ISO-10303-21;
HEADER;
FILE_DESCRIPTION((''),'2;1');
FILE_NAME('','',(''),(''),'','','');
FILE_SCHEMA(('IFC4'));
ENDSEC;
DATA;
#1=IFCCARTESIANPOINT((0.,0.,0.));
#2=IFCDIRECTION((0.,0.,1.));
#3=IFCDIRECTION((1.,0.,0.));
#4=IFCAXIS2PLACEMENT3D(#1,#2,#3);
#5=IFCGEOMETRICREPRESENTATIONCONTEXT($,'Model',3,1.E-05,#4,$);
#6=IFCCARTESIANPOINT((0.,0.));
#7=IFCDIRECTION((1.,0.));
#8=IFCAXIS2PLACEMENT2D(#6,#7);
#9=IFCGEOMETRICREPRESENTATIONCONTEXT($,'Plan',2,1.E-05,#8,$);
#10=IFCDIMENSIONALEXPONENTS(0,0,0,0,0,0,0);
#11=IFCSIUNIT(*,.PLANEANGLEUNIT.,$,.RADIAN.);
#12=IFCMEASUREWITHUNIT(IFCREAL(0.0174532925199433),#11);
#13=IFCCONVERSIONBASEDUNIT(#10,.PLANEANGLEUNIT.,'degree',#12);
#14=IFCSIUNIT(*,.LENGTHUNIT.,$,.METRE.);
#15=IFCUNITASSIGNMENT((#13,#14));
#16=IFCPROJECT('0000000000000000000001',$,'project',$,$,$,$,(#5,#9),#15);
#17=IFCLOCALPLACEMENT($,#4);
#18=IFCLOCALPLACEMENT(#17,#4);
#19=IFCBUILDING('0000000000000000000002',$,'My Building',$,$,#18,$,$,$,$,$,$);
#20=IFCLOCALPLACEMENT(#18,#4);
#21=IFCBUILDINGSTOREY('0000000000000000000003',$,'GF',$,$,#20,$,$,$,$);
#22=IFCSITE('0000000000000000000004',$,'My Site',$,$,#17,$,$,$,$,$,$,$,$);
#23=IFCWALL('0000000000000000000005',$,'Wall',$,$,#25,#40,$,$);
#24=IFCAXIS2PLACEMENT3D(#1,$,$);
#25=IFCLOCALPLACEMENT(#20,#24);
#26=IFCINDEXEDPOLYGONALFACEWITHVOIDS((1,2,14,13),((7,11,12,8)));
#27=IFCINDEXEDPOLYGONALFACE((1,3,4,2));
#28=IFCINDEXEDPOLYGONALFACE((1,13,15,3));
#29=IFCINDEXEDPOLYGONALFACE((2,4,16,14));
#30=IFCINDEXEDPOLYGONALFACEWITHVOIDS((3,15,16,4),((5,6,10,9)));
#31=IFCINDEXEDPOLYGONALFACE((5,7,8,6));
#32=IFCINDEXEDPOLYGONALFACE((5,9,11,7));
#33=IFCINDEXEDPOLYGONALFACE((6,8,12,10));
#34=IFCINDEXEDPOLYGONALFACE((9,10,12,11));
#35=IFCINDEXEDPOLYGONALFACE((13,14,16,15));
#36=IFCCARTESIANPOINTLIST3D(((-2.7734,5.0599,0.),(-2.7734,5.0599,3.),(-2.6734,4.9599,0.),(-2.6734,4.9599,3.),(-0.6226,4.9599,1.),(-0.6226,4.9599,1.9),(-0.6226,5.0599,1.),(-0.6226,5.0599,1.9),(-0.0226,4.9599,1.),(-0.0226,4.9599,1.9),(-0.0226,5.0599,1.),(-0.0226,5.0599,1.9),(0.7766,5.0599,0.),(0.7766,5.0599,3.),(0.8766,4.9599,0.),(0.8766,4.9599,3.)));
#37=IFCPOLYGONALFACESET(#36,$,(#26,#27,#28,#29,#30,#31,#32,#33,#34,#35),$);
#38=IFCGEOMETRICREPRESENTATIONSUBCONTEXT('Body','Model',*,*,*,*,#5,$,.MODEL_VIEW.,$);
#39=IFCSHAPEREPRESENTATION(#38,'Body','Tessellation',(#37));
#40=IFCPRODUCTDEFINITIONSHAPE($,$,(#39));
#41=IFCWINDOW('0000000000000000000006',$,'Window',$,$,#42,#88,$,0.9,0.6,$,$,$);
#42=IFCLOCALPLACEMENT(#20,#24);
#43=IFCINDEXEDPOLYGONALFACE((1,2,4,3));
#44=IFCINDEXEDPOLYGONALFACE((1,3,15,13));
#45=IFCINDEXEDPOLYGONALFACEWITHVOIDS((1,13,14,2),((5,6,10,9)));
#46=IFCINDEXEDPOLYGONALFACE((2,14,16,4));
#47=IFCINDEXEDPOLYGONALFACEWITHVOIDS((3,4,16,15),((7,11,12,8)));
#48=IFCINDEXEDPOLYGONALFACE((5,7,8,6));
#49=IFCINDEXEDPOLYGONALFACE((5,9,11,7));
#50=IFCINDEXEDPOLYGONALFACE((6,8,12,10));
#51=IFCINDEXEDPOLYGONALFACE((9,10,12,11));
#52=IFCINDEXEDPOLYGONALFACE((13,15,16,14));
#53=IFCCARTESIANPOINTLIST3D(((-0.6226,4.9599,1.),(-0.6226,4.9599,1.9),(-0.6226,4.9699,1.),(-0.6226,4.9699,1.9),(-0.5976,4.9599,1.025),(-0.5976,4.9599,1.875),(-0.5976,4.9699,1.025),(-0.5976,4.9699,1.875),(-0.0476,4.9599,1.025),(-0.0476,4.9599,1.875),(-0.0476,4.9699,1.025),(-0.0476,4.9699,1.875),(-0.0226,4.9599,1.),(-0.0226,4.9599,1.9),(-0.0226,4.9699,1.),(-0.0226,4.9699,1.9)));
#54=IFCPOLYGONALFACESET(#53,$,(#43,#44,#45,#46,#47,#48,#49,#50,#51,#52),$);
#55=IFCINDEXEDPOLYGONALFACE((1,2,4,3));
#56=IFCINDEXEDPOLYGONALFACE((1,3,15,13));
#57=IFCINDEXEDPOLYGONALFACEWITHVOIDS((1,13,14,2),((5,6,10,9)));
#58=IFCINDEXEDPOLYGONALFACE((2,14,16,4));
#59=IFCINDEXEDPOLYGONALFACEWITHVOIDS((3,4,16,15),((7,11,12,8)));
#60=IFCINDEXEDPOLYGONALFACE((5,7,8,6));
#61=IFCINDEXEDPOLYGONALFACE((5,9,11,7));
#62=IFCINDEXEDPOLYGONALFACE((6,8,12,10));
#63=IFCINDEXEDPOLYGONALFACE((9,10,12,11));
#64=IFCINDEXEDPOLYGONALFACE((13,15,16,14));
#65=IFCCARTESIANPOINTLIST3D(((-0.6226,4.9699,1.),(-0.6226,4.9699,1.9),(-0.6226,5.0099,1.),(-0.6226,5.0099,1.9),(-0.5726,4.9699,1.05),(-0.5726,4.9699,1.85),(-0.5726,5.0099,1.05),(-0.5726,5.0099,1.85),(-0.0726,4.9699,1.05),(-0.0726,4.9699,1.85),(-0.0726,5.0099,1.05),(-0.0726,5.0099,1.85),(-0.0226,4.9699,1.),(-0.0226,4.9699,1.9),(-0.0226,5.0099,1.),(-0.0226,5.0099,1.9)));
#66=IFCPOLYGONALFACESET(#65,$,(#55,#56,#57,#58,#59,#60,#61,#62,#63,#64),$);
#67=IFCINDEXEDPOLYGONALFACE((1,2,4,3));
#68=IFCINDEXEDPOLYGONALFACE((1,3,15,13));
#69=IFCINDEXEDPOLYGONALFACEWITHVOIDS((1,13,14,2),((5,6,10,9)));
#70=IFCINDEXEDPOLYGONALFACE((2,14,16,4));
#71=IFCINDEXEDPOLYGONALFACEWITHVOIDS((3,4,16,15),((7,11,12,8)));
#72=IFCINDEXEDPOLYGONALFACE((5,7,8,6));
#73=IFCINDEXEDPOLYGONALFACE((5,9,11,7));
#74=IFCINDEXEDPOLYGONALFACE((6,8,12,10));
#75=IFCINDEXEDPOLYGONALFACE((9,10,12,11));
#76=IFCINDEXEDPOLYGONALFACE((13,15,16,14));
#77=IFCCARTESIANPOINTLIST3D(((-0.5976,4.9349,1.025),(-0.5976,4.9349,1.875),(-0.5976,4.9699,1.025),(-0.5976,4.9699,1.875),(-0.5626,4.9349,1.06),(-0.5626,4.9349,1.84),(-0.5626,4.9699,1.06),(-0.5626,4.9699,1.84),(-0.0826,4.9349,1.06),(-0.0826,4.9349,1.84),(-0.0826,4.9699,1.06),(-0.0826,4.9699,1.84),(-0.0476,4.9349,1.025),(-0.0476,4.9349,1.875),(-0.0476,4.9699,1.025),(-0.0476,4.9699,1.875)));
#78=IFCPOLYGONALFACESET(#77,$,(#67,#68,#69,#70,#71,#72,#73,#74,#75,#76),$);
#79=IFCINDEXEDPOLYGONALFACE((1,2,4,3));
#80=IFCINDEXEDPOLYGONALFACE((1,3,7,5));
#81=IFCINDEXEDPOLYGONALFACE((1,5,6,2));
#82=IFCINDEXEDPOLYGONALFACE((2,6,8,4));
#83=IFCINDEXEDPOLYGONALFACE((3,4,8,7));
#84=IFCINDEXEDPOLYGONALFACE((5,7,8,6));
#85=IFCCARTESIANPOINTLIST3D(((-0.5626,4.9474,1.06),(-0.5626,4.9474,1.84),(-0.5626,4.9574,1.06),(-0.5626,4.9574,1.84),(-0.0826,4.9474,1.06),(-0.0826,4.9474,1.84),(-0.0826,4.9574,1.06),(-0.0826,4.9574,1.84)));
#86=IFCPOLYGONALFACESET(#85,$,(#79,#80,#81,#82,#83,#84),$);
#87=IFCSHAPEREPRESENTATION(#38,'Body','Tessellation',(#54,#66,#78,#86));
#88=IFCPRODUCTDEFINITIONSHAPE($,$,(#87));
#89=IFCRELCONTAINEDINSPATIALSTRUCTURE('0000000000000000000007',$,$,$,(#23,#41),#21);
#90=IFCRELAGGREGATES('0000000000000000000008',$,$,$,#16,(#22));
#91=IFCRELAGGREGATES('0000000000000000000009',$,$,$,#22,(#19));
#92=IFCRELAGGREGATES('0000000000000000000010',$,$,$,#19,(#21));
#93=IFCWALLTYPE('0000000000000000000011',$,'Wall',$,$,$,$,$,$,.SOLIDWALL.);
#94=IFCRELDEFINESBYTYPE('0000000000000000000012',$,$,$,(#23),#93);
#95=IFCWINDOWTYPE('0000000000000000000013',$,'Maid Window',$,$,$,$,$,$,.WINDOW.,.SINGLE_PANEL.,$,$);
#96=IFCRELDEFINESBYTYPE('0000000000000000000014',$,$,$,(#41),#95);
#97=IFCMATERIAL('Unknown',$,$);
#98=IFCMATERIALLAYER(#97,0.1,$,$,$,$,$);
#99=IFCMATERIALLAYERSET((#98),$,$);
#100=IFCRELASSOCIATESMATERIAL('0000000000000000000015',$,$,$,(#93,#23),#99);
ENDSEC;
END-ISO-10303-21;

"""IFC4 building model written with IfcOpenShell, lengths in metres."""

from ifc_helpers import new_model, entity, si_unit, converted_unit, frame, origin_with_axes, origin_2d_with_axis, place, context, subcontext, project, spatial, line, indexed_curve, outline, extrude, shape, source, transform, mapped, material, layer, layer_set, layer_usage, type_object, type_shapes, element, fill, save


model = new_model("IFC4")

# Units and contexts
model_context = context("Model", 3, precision=1e-05, world=origin_with_axes())
plan_context = context("Plan", 2, precision=1e-05, world=origin_2d_with_axis())
body_context_1 = subcontext(model_context, "Body", "Model", "MODEL_VIEW")
body_context_2 = subcontext(plan_context, "Body", "Plan", "PLAN_VIEW")
ifc_project = project(units=[converted_unit("PLANEANGLEUNIT", "degree", entity("IfcReal", 0.0174532925199433), si_unit("PLANEANGLEUNIT", "RADIAN"), dimensions=[0, 0, 0, 0, 0, 0, 0]), si_unit("LENGTHUNIT", "METRE")], contexts=[model_context, plan_context])

# Site, building, storey
site_placement = place(None, origin_with_axes())
site = spatial("IfcSite", under=ifc_project, at=site_placement, Name="My Site")
building_placement = place(site_placement, origin_with_axes())
building = spatial("IfcBuilding", under=site, at=building_placement, Name="My Building")
storey_placement = place(building_placement, origin_with_axes())
storey = spatial("IfcBuildingStorey", under=building, at=storey_placement, Name="GF")

# Shared definitions
ifc_material = material(Name="Unknown")

# Shared definitions
ifc_layer = layer(ifc_material, 0.1)
ifc_layer_set = layer_set([ifc_layer])
wall_type = type_object("IfcWallType", Name="Wall", PredefinedType="SOLIDWALL", material=ifc_layer_set)

# Wall, opening, window
ifc_layer_usage_1 = layer_usage(ifc_layer_set, "AXIS2", "POSITIVE", 0.0)
wall_1_placement = place(storey_placement, frame((0.7766, 5.0599, 0.0), z_axis=(0.0, 0.0, 1.0), x_axis=(-1.0, 0.0, 0.0)))
wall_1 = element("IfcWall", 1, at=wall_1_placement, inside=storey, type_object=wall_type, material=ifc_layer_usage_1, Name="Wall", context=body_context_1, shape_type="SweptSolid", body=[
    extrude(outline(indexed_curve([(0.0, 0.0), (-0.1, 0.1), (3.45, 0.1), (3.55, 0.0)], segments=[line(1, 2, 3, 4, 1)])), origin_with_axes(), (0.0, 0.0, 1.0), 3.0),
])
shared_shape_1 = source(origin_with_axes(), body_context_1, "Body", "SweptSolid", [
    extrude(outline(indexed_curve([(0.0, 0.0), (0.6, 0.0), (0.6, 0.9), (0.0, 0.9)], segments=[line(1, 2, 3, 4, 1)])), frame((0.0, -0.6, 0.0), z_axis=(0.0, -1.0, 0.0), x_axis=(1.0, 0.0, 0.0)), (0.0, 0.0, -1.0), 1.2),
])
opening_1_placement = place(wall_1_placement, frame((0.7992, 0.0, 1.0), z_axis=(0.0, 0.0, 1.0), x_axis=(1.0, 0.0, 0.0)))
opening_1 = element("IfcOpeningElement", 2, at=opening_1_placement, cuts=wall_1, PredefinedType="OPENING", context=body_context_1, shape_type="MappedRepresentation", body=[
    mapped(shared_shape_1, transform((0.0, 0.0, 0.0), x_axis=(1.0, 0.0, 0.0), y_axis=(0.0, 1.0, 0.0), z_axis=(0.0, 0.0, 1.0), scale=1.0)),
])
window_type_1 = type_object("IfcWindowType", Name="Maid Window", PartitioningType="SINGLE_PANEL", PredefinedType="WINDOW")
shared_shape_2 = source(origin_with_axes(), body_context_1, "Body", "SweptSolid", [
    extrude(outline(indexed_curve([(0.0, 0.0), (0.6, 0.0), (0.6, 0.9), (0.0, 0.9)], segments=[line(1, 2, 3, 4, 1)]), holes=[indexed_curve([(0.025, 0.025), (0.575, 0.025), (0.575, 0.875), (0.025, 0.875)], segments=[line(1, 2, 3, 4, 1)])]), frame((0.0, 0.09, 0.0), z_axis=(0.0, -1.0, 0.0), x_axis=(1.0, 0.0, 0.0)), (0.0, 0.0, -1.0), 0.01),
    extrude(outline(indexed_curve([(0.0, 0.0), (0.6, 0.0), (0.6, 0.9), (0.0, 0.9)], segments=[line(1, 2, 3, 4, 1)]), holes=[indexed_curve([(0.05, 0.05), (0.55, 0.05), (0.55, 0.85), (0.05, 0.85)], segments=[line(1, 2, 3, 4, 1)])]), frame((0.0, 0.05, 0.0), z_axis=(0.0, -1.0, 0.0), x_axis=(1.0, 0.0, 0.0)), (0.0, 0.0, -1.0), 0.04),
    extrude(outline(indexed_curve([(0.0, 0.0), (0.55, 0.0), (0.55, 0.85), (0.0, 0.85)], segments=[line(1, 2, 3, 4, 1)]), holes=[indexed_curve([(0.035, 0.035), (0.515, 0.035), (0.515, 0.815), (0.035, 0.815)], segments=[line(1, 2, 3, 4, 1)])]), frame((0.025, 0.09, 0.025), z_axis=(0.0, -1.0, 0.0), x_axis=(1.0, 0.0, 0.0)), (0.0, 0.0, -1.0), 0.035),
    extrude(outline(indexed_curve([(0.035, 0.035), (0.515, 0.035), (0.515, 0.815), (0.035, 0.815)], segments=[line(1, 2, 3, 4, 1)])), frame((0.025, 0.1025, 0.025), z_axis=(0.0, -1.0, 0.0), x_axis=(1.0, 0.0, 0.0)), (0.0, 0.0, -1.0), 0.01),
])
shared_shape_3 = source(origin_with_axes(), body_context_2, "Body", "Curve2D", [
    entity("IfcIndexedPolyCurve", entity("IfcCartesianPointList2D", [[0.05, 0.05], [0.55, 0.05]])),
    entity("IfcIndexedPolyCurve", entity("IfcCartesianPointList2D", [[0.0, 0.1], [0.025, 0.1], [0.025, 0.09], [0.05, 0.09], [0.05, 0.05], [0.0, 0.05]]), [entity("IfcLineIndex", [1, 2, 3, 4, 5, 6, 1])]),
    entity("IfcIndexedPolyCurve", entity("IfcCartesianPointList2D", [[0.6, 0.1], [0.575, 0.1], [0.575, 0.09], [0.55, 0.09], [0.55, 0.05], [0.6, 0.05]]), [entity("IfcLineIndex", [1, 2, 3, 4, 5, 6, 1])]),
    entity("IfcIndexedPolyCurve", entity("IfcCartesianPointList2D", [[0.025, 0.09], [0.06, 0.09], [0.06, 0.125], [0.025, 0.125]]), [entity("IfcLineIndex", [1, 2, 3, 4, 1])]),
    entity("IfcIndexedPolyCurve", entity("IfcCartesianPointList2D", [[0.575, 0.09], [0.54, 0.09], [0.54, 0.125], [0.575, 0.125]]), [entity("IfcLineIndex", [1, 2, 3, 4, 1])]),
    entity("IfcIndexedPolyCurve", entity("IfcCartesianPointList2D", [[0.06, 0.09], [0.54, 0.09]])),
    entity("IfcIndexedPolyCurve", entity("IfcCartesianPointList2D", [[0.06, 0.125], [0.54, 0.125]])),
    entity("IfcIndexedPolyCurve", entity("IfcCartesianPointList2D", [[0.06, 0.1075], [0.54, 0.1075]])),
])
type_shapes(window_type_1, [shared_shape_2, shared_shape_3])
window_1_placement = place(opening_1_placement, frame((0.0, 0.0, 0.0), z_axis=(0.0, 0.0, 1.0), x_axis=(1.0, 0.0, 0.0)))
window_1 = element("IfcWindow", 3, at=window_1_placement, inside=storey, type_object=window_type_1, Name="Window", OverallHeight=0.9, OverallWidth=0.6, shapes=[
    shape(body_context_1, "Body", "MappedRepresentation", [mapped(shared_shape_2, transform((0.0, 0.0, 0.0), x_axis=(1.0, 0.0, 0.0), y_axis=(0.0, 1.0, 0.0), z_axis=(0.0, 0.0, 1.0), scale=1.0))]),
    shape(body_context_2, "Body", "MappedRepresentation", [mapped(shared_shape_3, transform((0.0, 0.0, 0.0), x_axis=(1.0, 0.0, 0.0), y_axis=(0.0, 1.0, 0.0), z_axis=(0.0, 0.0, 1.0), scale=1.0))]),
])
fill(opening_1, window_1)

save(model, "model.ifc")
